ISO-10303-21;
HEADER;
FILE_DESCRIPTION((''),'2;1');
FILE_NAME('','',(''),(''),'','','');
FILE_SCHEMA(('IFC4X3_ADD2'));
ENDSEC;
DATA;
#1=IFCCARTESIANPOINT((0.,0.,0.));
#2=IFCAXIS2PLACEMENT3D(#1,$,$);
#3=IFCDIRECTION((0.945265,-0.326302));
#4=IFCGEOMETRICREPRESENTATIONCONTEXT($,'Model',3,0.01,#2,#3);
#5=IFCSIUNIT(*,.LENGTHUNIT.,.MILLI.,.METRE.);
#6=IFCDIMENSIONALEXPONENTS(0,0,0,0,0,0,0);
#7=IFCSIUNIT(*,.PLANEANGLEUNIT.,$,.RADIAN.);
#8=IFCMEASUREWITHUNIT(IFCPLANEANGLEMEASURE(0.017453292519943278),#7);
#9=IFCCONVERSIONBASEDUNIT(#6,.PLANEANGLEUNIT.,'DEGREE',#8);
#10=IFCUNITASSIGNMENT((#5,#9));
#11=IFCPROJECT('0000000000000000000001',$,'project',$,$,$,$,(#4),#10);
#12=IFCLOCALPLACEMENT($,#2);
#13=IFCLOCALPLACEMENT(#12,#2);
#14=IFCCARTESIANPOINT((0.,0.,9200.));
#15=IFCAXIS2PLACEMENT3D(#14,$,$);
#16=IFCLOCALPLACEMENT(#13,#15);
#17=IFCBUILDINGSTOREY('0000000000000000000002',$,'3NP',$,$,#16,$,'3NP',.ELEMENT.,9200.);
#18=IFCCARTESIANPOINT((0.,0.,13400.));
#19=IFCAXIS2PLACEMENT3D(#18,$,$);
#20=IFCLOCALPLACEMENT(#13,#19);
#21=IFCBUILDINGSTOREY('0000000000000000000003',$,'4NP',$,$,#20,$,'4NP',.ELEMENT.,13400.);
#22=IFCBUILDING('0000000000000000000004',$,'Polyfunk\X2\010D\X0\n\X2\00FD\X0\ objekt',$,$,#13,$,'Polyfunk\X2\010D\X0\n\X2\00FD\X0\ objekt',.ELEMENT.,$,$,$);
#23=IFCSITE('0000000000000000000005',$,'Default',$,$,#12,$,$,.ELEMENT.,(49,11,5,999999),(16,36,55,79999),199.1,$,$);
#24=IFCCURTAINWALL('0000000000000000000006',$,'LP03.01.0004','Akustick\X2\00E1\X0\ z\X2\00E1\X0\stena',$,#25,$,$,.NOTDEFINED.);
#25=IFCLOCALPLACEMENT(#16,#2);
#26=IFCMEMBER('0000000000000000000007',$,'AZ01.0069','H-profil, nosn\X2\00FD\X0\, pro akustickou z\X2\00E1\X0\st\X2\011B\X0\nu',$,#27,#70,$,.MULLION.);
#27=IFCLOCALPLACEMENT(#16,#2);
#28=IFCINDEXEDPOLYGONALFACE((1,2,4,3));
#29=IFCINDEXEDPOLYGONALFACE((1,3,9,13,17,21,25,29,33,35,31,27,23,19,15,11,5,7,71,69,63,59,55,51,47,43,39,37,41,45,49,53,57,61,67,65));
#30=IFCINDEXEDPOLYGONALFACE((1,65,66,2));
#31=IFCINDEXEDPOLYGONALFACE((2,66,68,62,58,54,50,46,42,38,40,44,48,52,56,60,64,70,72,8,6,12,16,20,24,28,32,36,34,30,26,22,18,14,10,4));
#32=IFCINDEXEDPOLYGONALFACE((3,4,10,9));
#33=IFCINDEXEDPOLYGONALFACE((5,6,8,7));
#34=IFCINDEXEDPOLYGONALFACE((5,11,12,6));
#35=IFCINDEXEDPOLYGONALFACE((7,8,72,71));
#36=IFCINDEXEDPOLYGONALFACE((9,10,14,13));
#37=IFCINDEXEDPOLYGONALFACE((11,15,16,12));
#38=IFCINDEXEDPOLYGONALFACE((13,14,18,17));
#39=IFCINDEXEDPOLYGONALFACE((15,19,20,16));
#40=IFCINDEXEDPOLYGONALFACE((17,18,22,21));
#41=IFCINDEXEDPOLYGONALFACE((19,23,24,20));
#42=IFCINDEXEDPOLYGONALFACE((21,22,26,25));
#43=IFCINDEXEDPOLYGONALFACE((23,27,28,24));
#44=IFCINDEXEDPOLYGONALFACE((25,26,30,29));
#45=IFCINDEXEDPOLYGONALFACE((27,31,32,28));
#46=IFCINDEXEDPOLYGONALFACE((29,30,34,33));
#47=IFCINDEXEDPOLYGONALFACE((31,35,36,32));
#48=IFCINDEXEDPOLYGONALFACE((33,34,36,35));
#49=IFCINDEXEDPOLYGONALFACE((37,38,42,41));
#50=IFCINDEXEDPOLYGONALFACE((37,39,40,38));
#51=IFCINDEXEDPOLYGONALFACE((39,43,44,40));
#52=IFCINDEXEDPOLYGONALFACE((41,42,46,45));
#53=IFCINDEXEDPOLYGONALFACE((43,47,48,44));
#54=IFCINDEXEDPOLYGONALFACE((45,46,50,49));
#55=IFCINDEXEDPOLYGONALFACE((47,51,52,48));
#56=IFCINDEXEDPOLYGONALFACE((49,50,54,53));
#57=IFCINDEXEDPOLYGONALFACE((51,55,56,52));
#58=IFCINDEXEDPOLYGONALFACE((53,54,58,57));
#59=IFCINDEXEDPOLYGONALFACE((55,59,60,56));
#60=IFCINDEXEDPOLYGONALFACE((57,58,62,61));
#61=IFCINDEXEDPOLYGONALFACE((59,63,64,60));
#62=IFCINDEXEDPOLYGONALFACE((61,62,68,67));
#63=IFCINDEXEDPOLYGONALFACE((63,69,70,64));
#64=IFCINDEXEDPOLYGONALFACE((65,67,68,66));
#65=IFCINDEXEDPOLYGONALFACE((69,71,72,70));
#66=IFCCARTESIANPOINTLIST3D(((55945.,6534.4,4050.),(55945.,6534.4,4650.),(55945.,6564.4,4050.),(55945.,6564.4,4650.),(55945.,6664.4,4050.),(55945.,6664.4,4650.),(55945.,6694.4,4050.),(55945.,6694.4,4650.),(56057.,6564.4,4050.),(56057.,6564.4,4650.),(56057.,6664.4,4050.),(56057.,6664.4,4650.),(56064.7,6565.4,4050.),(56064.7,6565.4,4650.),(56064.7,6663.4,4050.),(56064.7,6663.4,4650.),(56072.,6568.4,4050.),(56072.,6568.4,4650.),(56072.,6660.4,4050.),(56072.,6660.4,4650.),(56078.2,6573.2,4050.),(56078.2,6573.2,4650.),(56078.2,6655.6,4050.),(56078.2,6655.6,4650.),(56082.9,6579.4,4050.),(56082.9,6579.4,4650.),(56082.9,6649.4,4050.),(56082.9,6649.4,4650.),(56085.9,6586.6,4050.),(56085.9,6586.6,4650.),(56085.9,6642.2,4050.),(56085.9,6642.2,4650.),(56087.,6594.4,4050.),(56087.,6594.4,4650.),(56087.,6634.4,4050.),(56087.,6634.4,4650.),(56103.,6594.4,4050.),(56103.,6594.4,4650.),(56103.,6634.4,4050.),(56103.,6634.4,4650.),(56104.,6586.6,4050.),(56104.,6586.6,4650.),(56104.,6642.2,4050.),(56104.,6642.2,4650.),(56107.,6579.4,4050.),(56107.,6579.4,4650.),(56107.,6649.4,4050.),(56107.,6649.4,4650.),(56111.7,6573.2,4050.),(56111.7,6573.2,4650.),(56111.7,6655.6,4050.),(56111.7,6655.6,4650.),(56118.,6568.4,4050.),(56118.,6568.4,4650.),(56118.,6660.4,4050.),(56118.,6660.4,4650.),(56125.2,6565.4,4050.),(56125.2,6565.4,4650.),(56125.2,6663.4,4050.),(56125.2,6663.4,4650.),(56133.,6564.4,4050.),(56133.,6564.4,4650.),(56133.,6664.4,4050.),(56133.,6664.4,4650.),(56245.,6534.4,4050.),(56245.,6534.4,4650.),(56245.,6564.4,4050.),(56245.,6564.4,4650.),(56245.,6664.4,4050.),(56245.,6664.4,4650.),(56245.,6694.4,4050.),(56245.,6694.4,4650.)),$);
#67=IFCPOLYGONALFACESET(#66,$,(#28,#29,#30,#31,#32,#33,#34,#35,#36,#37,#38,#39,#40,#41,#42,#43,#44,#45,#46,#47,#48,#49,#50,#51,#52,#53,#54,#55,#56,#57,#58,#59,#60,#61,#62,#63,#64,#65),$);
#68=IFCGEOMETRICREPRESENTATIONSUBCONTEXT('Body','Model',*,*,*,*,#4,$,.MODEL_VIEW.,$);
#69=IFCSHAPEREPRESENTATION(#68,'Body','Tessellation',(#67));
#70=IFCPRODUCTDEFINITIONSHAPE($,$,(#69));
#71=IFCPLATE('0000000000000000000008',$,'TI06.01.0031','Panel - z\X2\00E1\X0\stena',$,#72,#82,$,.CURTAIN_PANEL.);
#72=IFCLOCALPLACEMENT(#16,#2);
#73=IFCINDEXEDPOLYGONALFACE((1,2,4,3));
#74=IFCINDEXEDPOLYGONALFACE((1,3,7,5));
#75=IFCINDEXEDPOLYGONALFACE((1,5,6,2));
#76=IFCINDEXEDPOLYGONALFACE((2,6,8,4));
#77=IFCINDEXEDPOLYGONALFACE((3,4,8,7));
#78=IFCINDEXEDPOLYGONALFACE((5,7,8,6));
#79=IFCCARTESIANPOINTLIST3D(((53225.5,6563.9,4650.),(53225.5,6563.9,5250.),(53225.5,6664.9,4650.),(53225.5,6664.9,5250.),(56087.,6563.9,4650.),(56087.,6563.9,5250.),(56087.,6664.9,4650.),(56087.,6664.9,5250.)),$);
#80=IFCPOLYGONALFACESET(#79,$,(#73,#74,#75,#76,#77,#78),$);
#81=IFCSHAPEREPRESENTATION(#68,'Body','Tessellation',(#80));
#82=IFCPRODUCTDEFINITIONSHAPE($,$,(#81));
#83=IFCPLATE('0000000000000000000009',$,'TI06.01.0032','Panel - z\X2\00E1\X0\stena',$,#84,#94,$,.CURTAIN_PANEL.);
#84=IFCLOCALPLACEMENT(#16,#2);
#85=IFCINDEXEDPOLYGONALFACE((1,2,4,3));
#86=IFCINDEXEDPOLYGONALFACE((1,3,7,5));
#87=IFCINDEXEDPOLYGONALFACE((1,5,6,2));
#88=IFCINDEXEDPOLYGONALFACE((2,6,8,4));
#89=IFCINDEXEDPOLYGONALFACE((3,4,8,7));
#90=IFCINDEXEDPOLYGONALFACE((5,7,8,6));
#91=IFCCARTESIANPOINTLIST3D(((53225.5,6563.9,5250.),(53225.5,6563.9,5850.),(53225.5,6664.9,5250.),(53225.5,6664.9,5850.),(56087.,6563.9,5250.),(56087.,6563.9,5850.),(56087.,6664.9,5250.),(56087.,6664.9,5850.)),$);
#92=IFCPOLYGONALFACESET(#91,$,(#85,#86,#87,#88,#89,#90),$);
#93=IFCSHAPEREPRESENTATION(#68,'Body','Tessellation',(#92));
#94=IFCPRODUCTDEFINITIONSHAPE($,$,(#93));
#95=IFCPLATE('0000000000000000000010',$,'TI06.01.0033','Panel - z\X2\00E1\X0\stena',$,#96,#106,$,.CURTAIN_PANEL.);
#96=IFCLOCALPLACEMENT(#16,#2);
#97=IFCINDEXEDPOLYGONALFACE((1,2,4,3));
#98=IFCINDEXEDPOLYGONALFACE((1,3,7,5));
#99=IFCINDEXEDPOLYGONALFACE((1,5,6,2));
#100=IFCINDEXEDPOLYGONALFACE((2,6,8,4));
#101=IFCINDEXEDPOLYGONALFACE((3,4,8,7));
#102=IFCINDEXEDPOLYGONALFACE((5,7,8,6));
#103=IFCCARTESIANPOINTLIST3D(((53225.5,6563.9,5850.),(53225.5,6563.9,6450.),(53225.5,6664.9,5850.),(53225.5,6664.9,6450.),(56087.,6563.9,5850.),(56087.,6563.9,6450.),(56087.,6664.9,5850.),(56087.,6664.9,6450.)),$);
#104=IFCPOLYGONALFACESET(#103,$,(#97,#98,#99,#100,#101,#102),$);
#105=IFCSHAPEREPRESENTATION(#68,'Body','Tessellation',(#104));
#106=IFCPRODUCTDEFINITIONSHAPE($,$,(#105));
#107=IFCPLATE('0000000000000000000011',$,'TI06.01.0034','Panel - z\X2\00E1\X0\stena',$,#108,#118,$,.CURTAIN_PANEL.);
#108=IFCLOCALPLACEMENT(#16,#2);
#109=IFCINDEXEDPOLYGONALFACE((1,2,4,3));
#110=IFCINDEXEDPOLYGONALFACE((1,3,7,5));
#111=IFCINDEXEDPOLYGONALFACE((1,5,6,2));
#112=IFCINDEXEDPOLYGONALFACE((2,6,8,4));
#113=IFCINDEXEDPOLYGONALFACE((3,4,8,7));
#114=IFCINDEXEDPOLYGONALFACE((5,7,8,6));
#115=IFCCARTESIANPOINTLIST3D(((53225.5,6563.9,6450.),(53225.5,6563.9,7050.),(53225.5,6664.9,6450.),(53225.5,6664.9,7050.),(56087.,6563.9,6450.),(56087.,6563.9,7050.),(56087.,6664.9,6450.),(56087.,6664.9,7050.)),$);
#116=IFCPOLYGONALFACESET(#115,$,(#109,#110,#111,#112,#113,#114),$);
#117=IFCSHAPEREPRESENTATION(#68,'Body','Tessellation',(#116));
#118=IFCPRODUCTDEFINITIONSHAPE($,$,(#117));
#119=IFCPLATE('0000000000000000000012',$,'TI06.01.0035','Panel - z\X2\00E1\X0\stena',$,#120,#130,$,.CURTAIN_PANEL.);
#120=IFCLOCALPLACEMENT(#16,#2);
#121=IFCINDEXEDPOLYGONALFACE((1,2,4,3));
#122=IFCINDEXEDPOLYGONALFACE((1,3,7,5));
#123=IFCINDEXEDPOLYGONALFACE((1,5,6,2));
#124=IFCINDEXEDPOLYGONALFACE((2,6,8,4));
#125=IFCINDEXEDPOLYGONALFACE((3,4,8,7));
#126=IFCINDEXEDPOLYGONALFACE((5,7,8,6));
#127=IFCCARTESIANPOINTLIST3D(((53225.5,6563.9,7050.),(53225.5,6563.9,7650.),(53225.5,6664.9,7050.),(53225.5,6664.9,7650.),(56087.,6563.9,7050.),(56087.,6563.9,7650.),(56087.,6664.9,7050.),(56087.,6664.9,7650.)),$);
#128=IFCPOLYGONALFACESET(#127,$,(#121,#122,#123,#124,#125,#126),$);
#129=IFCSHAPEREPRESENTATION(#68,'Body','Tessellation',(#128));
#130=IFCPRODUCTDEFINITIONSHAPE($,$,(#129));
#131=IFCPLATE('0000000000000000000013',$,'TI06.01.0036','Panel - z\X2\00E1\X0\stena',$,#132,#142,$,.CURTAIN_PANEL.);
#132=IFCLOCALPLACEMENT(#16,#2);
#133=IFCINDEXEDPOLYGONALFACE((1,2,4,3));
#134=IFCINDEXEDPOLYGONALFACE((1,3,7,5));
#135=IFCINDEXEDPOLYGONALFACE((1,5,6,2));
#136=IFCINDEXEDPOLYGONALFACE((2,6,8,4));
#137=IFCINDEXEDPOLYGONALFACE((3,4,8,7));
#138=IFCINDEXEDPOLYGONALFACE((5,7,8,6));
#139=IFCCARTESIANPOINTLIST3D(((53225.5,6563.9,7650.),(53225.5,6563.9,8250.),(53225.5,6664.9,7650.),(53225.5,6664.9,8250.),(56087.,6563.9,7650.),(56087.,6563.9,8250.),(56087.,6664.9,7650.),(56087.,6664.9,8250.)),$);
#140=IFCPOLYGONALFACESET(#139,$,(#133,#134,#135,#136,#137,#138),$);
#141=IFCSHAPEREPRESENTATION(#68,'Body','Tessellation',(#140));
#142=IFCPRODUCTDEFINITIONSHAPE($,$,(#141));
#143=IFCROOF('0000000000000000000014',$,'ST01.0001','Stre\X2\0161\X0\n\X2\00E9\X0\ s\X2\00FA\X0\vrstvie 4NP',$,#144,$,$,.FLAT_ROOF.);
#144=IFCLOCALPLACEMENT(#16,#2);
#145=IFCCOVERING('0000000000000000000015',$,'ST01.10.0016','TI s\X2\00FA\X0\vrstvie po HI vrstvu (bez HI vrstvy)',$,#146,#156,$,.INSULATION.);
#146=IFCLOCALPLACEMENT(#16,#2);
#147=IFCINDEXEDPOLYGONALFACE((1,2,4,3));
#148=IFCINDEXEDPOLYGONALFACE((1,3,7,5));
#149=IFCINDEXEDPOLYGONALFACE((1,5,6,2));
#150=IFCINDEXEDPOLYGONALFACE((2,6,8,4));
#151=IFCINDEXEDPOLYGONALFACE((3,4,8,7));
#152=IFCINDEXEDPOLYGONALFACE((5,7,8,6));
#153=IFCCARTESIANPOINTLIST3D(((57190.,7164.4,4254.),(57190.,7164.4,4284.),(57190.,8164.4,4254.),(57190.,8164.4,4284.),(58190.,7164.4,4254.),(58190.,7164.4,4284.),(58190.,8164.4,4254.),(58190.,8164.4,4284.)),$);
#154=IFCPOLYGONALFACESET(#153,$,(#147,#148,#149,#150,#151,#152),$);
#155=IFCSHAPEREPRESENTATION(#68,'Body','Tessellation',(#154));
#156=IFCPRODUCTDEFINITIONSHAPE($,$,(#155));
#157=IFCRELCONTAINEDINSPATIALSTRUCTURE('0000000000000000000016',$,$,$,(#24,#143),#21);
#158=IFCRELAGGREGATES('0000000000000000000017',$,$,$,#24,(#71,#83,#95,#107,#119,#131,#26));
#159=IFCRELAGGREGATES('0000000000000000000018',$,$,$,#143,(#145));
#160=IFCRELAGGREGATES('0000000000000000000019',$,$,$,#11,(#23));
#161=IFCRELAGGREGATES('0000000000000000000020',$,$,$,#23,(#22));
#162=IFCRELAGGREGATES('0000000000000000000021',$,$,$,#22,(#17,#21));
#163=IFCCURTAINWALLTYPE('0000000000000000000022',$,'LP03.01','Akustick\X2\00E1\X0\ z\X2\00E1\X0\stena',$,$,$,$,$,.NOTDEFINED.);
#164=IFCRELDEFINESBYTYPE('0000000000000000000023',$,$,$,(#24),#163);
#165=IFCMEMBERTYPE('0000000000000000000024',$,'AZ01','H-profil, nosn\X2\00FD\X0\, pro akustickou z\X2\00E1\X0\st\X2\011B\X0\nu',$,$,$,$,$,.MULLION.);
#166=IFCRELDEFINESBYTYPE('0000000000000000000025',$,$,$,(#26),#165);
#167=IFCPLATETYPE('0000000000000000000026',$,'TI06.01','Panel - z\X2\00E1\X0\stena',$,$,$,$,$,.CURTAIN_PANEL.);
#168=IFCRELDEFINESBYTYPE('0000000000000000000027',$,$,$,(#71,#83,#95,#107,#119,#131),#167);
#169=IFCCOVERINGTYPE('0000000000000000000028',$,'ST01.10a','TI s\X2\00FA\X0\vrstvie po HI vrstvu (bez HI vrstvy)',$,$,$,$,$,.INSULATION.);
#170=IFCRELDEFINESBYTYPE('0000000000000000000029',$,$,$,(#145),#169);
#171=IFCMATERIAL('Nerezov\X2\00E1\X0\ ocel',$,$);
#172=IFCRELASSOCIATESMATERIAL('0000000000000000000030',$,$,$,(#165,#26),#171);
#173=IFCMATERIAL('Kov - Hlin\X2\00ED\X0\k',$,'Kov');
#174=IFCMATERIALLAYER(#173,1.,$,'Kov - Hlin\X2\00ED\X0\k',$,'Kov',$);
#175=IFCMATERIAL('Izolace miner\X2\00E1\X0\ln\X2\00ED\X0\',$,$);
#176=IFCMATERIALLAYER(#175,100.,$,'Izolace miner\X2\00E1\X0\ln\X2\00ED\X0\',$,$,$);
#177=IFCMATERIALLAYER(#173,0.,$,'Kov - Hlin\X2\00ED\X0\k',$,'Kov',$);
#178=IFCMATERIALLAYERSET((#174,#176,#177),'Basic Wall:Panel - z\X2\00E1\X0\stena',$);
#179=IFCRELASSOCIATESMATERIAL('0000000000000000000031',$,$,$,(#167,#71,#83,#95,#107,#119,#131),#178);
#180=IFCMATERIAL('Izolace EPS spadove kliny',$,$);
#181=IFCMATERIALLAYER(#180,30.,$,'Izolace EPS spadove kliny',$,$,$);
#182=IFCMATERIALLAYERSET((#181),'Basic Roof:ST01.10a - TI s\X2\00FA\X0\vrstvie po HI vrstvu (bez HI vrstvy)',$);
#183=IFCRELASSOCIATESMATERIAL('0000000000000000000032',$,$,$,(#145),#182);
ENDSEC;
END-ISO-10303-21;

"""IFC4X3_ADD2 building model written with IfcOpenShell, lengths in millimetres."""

from ifc_helpers import new_model, entity, si_unit, converted_unit, direction, frame, frame_2d, origin, origin_2d_with_axis, place, context, subcontext, project, spatial, polyline, circle_curve, parameter, trimmed, segment, composite_curve, rectangle, outline, extrude, source, transform, mapped, material, layer, layer_set, layer_usage, material_profile, profile_set, profile_usage, type_object, element, aggregate, save


model = new_model("IFC4X3_ADD2")

# Units and contexts
model_context = context("Model", 3, precision=0.01, world=origin(), true_north=direction((0.945265, -0.326302)))
body_context = subcontext(model_context, "Body", "Model", "MODEL_VIEW")
ifc_project = project(units=[si_unit("LENGTHUNIT", "METRE", prefix="MILLI"), converted_unit("PLANEANGLEUNIT", "DEGREE", entity("IfcPlaneAngleMeasure", 0.017453292519943278), si_unit("PLANEANGLEUNIT", "RADIAN"), dimensions=[0, 0, 0, 0, 0, 0, 0])], contexts=[model_context])

# Site, building, storey
site_placement = place(None, origin())
site = spatial("IfcSite", under=ifc_project, at=site_placement, Name="Default", CompositionType="ELEMENT", RefLatitude=(49, 11, 5, 999999), RefLongitude=(16, 36, 55, 79999), RefElevation=199.1)
building_placement = place(site_placement, origin())
building = spatial("IfcBuilding", under=site, at=building_placement, Name="Polyfunkčný objekt", LongName="Polyfunkčný objekt", CompositionType="ELEMENT")
storey_1_placement = place(building_placement, frame((0.0, 0.0, 9200.0)))
storey_1 = spatial("IfcBuildingStorey", under=building, at=storey_1_placement, Name="3NP", LongName="3NP", CompositionType="ELEMENT", Elevation=9200.0)

# Shared definitions
storey_2_placement = place(building_placement, frame((0.0, 0.0, 13400.0)))
storey_2 = spatial("IfcBuildingStorey", under=building, at=storey_2_placement, Name="4NP", LongName="4NP", CompositionType="ELEMENT", Elevation=13400.0)

# Curtain wall, member, plates
curtain_wall_type_1 = type_object("IfcCurtainWallType", Name="LP03.01", Description="Akustická zástena", PredefinedType="NOTDEFINED")
curtain_wall_1_placement = place(storey_2_placement, frame((0.0, 0.0, -13400.0)))
curtain_wall_1 = element("IfcCurtainWall", 1, at=curtain_wall_1_placement, inside=storey_2, type_object=curtain_wall_type_1, Name="LP03.01.0004", Description="Akustická zástena", PredefinedType="NOTDEFINED")
ifc_material_1 = material(Name="Nerezová ocel")
ifc_material_profile_1 = material_profile(ifc_material_1, outline(composite_curve([segment(polyline([(50.0, -150.0), (80.0, -150.0)]), True, "CONTINUOUS"), segment(polyline([(80.0, -150.0), (80.0, 150.0)]), True, "CONTINUOUS"), segment(polyline([(80.0, 150.0), (50.0, 150.0)]), True, "CONTINUOUS"), segment(polyline([(50.0, 150.0), (50.0, 38.0)]), True, "CONTINUOUS"), segment(trimmed(circle_curve(frame_2d((20.0, 38.0), x_axis=(0.0, 1.0)), 30.0), [parameter(180.0)], [parameter(270.0)], True, "PARAMETER"), False, "CONTINUOUS"), segment(polyline([(20.0, 8.0), (-20.0, 8.0)]), True, "CONTINUOUS"), segment(trimmed(circle_curve(frame_2d((-20.0, 38.0), x_axis=(0.0, 1.0)), 30.0), [parameter(90.0)], [parameter(180.0)], True, "PARAMETER"), False, "CONTINUOUS"), segment(polyline([(-50.0, 38.0), (-50.0, 150.0)]), True, "CONTINUOUS"), segment(polyline([(-50.0, 150.0), (-80.0, 150.0)]), True, "CONTINUOUS"), segment(polyline([(-80.0, 150.0), (-80.0, -150.0)]), True, "CONTINUOUS"), segment(polyline([(-80.0, -150.0), (-50.0, -150.0)]), True, "CONTINUOUS"), segment(polyline([(-50.0, -150.0), (-50.0, -38.0)]), True, "CONTINUOUS"), segment(trimmed(circle_curve(frame_2d((-20.0, -38.0), x_axis=(0.0, 1.0)), 30.0), [parameter(0.0)], [parameter(90.0)], True, "PARAMETER"), False, "CONTINUOUS"), segment(polyline([(-20.0, -8.0), (20.0, -8.0)]), True, "CONTINUOUS"), segment(trimmed(circle_curve(frame_2d((20.0, -38.0), x_axis=(0.0, 1.0)), 30.0), [parameter(270.0)], [parameter(0.0)], True, "PARAMETER"), False, "CONTINUOUS"), segment(polyline([(50.0, -38.0), (50.0, -150.0)]), True, "CONTINUOUS")], self_intersect=False)), Name="Profil zástena")
ifc_profile_set_1 = profile_set([ifc_material_profile_1], Name="Profil zástena")
ifc_profile_usage_1 = profile_usage(ifc_profile_set_1)
member_type_1 = type_object("IfcMemberType", Name="AZ01", Description="H-profil, nosný, pro akustickou zástěnu", PredefinedType="MULLION", material=ifc_profile_set_1)
shared_shape_1 = source(origin(), body_context, "Body", "SweptSolid", [
    extrude(outline(composite_curve([segment(polyline([(50.0, -150.0), (80.0, -150.0)]), True, "CONTINUOUS"), segment(polyline([(80.0, -150.0), (80.0, 150.0)]), True, "CONTINUOUS"), segment(polyline([(80.0, 150.0), (50.0, 150.0)]), True, "CONTINUOUS"), segment(polyline([(50.0, 150.0), (50.0, 38.0)]), True, "CONTINUOUS"), segment(trimmed(circle_curve(frame_2d((20.0, 38.0), x_axis=(0.0, 1.0)), 30.0), [parameter(180.0)], [parameter(270.0)], True, "PARAMETER"), False, "CONTINUOUS"), segment(polyline([(20.0, 8.0), (-20.0, 8.0)]), True, "CONTINUOUS"), segment(trimmed(circle_curve(frame_2d((-20.0, 38.0), x_axis=(0.0, 1.0)), 30.0), [parameter(90.0)], [parameter(180.0)], True, "PARAMETER"), False, "CONTINUOUS"), segment(polyline([(-50.0, 38.0), (-50.0, 150.0)]), True, "CONTINUOUS"), segment(polyline([(-50.0, 150.0), (-80.0, 150.0)]), True, "CONTINUOUS"), segment(polyline([(-80.0, 150.0), (-80.0, -150.0)]), True, "CONTINUOUS"), segment(polyline([(-80.0, -150.0), (-50.0, -150.0)]), True, "CONTINUOUS"), segment(polyline([(-50.0, -150.0), (-50.0, -38.0)]), True, "CONTINUOUS"), segment(trimmed(circle_curve(frame_2d((-20.0, -38.0), x_axis=(0.0, 1.0)), 30.0), [parameter(0.0)], [parameter(90.0)], True, "PARAMETER"), False, "CONTINUOUS"), segment(polyline([(-20.0, -8.0), (20.0, -8.0)]), True, "CONTINUOUS"), segment(trimmed(circle_curve(frame_2d((20.0, -38.0), x_axis=(0.0, 1.0)), 30.0), [parameter(270.0)], [parameter(0.0)], True, "PARAMETER"), False, "CONTINUOUS"), segment(polyline([(50.0, -38.0), (50.0, -150.0)]), True, "CONTINUOUS")], self_intersect=False)), frame((-150.0, 0.0, -600.0), z_axis=(0.0, 0.0, 1.0), x_axis=(0.0, -1.0, 0.0)), (0.0, 0.0, 1.0), 600.0),
])
member_1_placement = place(curtain_wall_1_placement, frame((56245.0, 6614.4, 13250.0), z_axis=(0.0, 0.0, -1.0), x_axis=(1.0, 0.0, 0.0)))
member_1 = element("IfcMember", 2, at=member_1_placement, type_object=member_type_1, material=ifc_profile_usage_1, Name="AZ01.0069", Description="H-profil, nosný, pro akustickou zástěnu", PredefinedType="MULLION", context=body_context, shape_type="MappedRepresentation", body=[
    mapped(shared_shape_1, transform((0.0, 0.0, 0.0), scale=1.0)),
])
ifc_material_2 = material(Name="Kov - Hliník", Category="Kov")
ifc_layer_1 = layer(ifc_material_2, 1.0, Name="Kov - Hliník", Category="Kov")
ifc_material_3 = material(Name="Izolace minerální")
ifc_layer_2 = layer(ifc_material_3, 100.0, Name="Izolace minerální")
ifc_layer_3 = layer(ifc_material_2, 0.0, Name="Kov - Hliník", Category="Kov")
ifc_layer_set_1 = layer_set([ifc_layer_1, ifc_layer_2, ifc_layer_3], Name="Basic Wall:Panel - zástena")
ifc_layer_usage_1 = layer_usage(ifc_layer_set_1, "AXIS2", "POSITIVE", -50.5)
plate_type = type_object("IfcPlateType", Name="TI06.01", Description="Panel - zástena", PredefinedType="CURTAIN_PANEL", material=ifc_layer_set_1)
plate_1_placement = place(storey_2_placement, frame((53225.5, 6614.4, 450.0)))
plate_1 = element("IfcPlate", 3, at=plate_1_placement, type_object=plate_type, material=ifc_layer_usage_1, Name="TI06.01.0031", Description="Panel - zástena", PredefinedType="CURTAIN_PANEL", context=body_context, shape_type="SweptSolid", body=[
    extrude(rectangle(XDim=101.0, YDim=2861.5, at=origin_2d_with_axis()), frame((1430.8, 0.0, 0.0), z_axis=(0.0, 0.0, 1.0), x_axis=(0.0, 1.0, 0.0)), (0.0, 0.0, 1.0), 600.0),
])
ifc_layer_usage_2 = layer_usage(ifc_layer_set_1, "AXIS2", "POSITIVE", -50.5)
plate_2_placement = place(storey_2_placement, frame((53225.5, 6614.4, 1050.0)))
plate_2 = element("IfcPlate", 4, at=plate_2_placement, type_object=plate_type, material=ifc_layer_usage_2, Name="TI06.01.0032", Description="Panel - zástena", PredefinedType="CURTAIN_PANEL", context=body_context, shape_type="SweptSolid", body=[
    extrude(rectangle(XDim=101.0, YDim=2861.5, at=frame_2d((0.0, 0.0), x_axis=(1.0, 0.0))), frame((1430.7, 0.0, 0.0), z_axis=(0.0, 0.0, 1.0), x_axis=(0.0, 1.0, 0.0)), (0.0, 0.0, 1.0), 600.0),
])
ifc_layer_usage_3 = layer_usage(ifc_layer_set_1, "AXIS2", "POSITIVE", -50.5)
plate_3_placement = place(storey_2_placement, frame((53225.5, 6614.4, 1650.0)))
plate_3 = element("IfcPlate", 5, at=plate_3_placement, type_object=plate_type, material=ifc_layer_usage_3, Name="TI06.01.0033", Description="Panel - zástena", PredefinedType="CURTAIN_PANEL", context=body_context, shape_type="SweptSolid", body=[
    extrude(rectangle(XDim=101.0, YDim=2861.5, at=frame_2d((0.0, 0.0), x_axis=(1.0, 0.0))), frame((1430.7, 0.0, 0.0), z_axis=(0.0, 0.0, 1.0), x_axis=(0.0, 1.0, 0.0)), (0.0, 0.0, 1.0), 600.0),
])
ifc_layer_usage_4 = layer_usage(ifc_layer_set_1, "AXIS2", "POSITIVE", -50.5)
plate_4_placement = place(storey_2_placement, frame((53225.5, 6614.4, 2250.0)))
plate_4 = element("IfcPlate", 6, at=plate_4_placement, type_object=plate_type, material=ifc_layer_usage_4, Name="TI06.01.0034", Description="Panel - zástena", PredefinedType="CURTAIN_PANEL", context=body_context, shape_type="SweptSolid", body=[
    extrude(rectangle(XDim=101.0, YDim=2861.5, at=frame_2d((0.0, 0.0), x_axis=(1.0, 0.0))), frame((1430.7, 0.0, 0.0), z_axis=(0.0, 0.0, 1.0), x_axis=(0.0, 1.0, 0.0)), (0.0, 0.0, 1.0), 600.0),
])
ifc_layer_usage_5 = layer_usage(ifc_layer_set_1, "AXIS2", "POSITIVE", -50.5)
plate_5_placement = place(storey_2_placement, frame((53225.5, 6614.4, 2850.0)))
plate_5 = element("IfcPlate", 7, at=plate_5_placement, type_object=plate_type, material=ifc_layer_usage_5, Name="TI06.01.0035", Description="Panel - zástena", PredefinedType="CURTAIN_PANEL", context=body_context, shape_type="SweptSolid", body=[
    extrude(rectangle(XDim=101.0, YDim=2861.5, at=frame_2d((0.0, 0.0), x_axis=(1.0, 0.0))), frame((1430.7, 0.0, 0.0), z_axis=(0.0, 0.0, 1.0), x_axis=(0.0, 1.0, 0.0)), (0.0, 0.0, 1.0), 600.0),
])
ifc_layer_usage_6 = layer_usage(ifc_layer_set_1, "AXIS2", "POSITIVE", -50.5)
plate_6_placement = place(storey_2_placement, frame((53225.5, 6614.4, 3450.0)))
plate_6 = element("IfcPlate", 8, at=plate_6_placement, type_object=plate_type, material=ifc_layer_usage_6, Name="TI06.01.0036", Description="Panel - zástena", PredefinedType="CURTAIN_PANEL", context=body_context, shape_type="SweptSolid", body=[
    extrude(rectangle(XDim=101.0, YDim=2861.5, at=origin_2d_with_axis()), frame((1430.8, 0.0, 0.0), z_axis=(0.0, 0.0, 1.0), x_axis=(0.0, 1.0, 0.0)), (0.0, 0.0, 1.0), 600.0),
])
aggregate(curtain_wall_1, [plate_1, plate_2, plate_3, plate_4, plate_5, plate_6, member_1])

# Roof, covering
roof = element("IfcRoof", 9, inside=storey_2, Name="ST01.0001", Description="Strešné súvrstvie 4NP", PredefinedType="FLAT_ROOF")
ifc_material_4 = material(Name="Izolace EPS spadove kliny")
ifc_layer_4 = layer(ifc_material_4, 30.0, Name="Izolace EPS spadove kliny")
ifc_layer_set_2 = layer_set([ifc_layer_4], Name="Basic Roof:ST01.10a - TI súvrstvie po HI vrstvu (bez HI vrstvy)")
covering_type_1 = type_object("IfcCoveringType", Name="ST01.10a", Description="TI súvrstvie po HI vrstvu (bez HI vrstvy)", PredefinedType="INSULATION")
placement_1 = place(storey_2_placement, frame((57190.0, 7164.4, 54.0)))
covering_1_placement = place(placement_1, origin())
covering_1 = element("IfcCovering", 10, at=covering_1_placement, type_object=covering_type_1, material=ifc_layer_set_2, Name="ST01.10.0016", Description="TI súvrstvie po HI vrstvu (bez HI vrstvy)", PredefinedType="INSULATION", context=body_context, shape_type="SweptSolid", body=[
    extrude(rectangle(XDim=1000.0, YDim=1000.0, at=frame_2d((0.0, 0.0), x_axis=(1.0, 0.0))), frame((500.0, 500.0, 0.0)), (0.0, 0.0, 1.0), 30.0),
])
aggregate(roof, [covering_1])

save(model, "model.ifc")
